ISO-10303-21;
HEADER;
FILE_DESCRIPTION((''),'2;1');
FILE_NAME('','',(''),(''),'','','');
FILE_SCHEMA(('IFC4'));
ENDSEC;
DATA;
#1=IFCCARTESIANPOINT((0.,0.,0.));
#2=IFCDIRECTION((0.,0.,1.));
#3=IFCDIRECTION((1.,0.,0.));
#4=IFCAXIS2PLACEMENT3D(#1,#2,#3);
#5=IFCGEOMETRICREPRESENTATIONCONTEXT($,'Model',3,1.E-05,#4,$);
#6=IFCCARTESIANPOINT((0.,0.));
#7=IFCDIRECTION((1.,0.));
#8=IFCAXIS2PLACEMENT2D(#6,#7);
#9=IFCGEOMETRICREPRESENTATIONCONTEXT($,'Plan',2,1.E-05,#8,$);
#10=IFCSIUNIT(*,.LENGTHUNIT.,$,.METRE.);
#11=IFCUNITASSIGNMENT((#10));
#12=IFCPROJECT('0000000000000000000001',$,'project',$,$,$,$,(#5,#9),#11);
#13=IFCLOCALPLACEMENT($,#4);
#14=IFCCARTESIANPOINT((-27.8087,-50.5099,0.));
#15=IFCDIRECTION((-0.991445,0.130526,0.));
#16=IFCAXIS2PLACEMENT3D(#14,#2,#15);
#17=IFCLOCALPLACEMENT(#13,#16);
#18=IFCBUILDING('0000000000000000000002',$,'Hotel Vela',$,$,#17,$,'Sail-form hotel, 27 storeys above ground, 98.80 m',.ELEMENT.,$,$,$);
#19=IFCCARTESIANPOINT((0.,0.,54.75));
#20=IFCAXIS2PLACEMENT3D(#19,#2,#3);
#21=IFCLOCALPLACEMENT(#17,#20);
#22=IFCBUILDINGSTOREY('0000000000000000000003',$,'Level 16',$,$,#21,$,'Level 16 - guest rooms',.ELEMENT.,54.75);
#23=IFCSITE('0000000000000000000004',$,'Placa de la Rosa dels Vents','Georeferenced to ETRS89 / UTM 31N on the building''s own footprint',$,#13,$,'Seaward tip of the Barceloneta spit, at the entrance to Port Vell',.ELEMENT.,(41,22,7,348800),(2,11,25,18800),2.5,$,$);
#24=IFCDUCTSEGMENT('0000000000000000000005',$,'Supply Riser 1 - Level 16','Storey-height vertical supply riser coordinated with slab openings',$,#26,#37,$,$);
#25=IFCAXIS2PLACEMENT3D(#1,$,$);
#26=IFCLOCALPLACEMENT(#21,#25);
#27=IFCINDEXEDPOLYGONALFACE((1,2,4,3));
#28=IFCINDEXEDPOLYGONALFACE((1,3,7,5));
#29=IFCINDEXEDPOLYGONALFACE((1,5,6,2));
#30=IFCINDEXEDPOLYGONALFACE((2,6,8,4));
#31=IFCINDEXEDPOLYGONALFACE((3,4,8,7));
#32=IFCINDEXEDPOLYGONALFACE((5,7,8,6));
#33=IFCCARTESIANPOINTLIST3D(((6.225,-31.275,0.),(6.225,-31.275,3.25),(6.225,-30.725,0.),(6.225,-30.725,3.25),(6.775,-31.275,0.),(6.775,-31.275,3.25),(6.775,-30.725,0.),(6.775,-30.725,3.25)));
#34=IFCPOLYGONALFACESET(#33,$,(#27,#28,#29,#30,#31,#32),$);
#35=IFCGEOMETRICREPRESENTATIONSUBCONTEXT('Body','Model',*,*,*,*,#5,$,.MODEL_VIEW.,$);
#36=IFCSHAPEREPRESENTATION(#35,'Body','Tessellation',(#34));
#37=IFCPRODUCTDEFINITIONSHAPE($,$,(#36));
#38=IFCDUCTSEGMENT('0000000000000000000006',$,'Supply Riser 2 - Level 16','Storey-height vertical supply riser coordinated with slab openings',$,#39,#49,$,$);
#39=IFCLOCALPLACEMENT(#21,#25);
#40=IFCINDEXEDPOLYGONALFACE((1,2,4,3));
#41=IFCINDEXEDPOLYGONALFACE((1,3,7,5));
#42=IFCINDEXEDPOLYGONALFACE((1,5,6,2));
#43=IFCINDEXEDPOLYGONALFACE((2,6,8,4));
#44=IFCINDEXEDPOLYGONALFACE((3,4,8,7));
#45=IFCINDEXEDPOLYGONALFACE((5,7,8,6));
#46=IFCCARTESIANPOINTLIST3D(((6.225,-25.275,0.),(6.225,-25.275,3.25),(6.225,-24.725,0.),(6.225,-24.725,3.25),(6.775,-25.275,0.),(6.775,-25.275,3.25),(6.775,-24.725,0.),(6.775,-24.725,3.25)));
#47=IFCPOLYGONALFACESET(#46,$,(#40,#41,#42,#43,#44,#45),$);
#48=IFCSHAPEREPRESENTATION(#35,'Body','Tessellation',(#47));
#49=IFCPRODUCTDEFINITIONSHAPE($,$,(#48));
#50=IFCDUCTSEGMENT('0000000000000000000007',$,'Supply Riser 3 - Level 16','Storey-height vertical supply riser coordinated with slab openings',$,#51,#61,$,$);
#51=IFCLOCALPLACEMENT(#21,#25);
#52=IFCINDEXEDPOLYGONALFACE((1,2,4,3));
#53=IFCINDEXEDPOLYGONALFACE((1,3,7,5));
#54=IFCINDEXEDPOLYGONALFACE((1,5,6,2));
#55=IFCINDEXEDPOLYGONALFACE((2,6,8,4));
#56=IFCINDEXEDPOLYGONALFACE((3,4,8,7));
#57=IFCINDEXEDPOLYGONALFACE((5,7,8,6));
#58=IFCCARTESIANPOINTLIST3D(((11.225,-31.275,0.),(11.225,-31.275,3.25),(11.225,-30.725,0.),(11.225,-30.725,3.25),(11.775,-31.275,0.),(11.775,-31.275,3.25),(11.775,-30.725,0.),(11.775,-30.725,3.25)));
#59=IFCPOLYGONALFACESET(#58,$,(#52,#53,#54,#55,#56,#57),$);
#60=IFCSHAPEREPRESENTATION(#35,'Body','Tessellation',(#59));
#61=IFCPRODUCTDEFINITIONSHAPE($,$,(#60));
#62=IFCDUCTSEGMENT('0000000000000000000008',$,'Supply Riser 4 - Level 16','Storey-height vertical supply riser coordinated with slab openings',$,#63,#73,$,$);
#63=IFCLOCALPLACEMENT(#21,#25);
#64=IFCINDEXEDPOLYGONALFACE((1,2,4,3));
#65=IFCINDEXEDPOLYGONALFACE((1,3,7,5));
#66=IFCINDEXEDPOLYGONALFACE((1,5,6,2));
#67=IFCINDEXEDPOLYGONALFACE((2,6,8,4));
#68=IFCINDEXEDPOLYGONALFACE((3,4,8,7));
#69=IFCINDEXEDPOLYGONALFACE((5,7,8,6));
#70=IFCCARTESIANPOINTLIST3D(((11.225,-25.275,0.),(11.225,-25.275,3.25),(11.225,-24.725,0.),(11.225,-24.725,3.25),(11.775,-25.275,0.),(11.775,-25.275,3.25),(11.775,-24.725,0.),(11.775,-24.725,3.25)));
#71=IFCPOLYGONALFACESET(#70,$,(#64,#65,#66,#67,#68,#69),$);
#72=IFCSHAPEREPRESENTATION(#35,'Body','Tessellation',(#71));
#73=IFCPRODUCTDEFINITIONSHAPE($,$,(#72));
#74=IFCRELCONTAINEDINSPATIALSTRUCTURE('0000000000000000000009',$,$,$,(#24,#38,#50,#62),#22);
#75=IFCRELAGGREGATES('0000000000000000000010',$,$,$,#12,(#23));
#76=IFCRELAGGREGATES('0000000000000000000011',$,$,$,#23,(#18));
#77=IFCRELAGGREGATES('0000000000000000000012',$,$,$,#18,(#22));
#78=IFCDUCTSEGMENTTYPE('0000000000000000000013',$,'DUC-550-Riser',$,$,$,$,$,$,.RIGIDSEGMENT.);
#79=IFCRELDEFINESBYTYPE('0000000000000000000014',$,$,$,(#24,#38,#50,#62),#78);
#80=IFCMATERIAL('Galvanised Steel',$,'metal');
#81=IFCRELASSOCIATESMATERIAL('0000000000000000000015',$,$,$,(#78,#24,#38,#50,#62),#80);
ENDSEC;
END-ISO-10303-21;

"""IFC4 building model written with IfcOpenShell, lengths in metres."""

from ifc_helpers import new_model, si_unit, frame, origin_with_axes, origin_2d_with_axis, place, context, subcontext, project, spatial, line, indexed_curve, outline, extrude, material, type_object, element, save


model = new_model("IFC4")

# Units and contexts
model_context = context("Model", 3, precision=1e-05, world=origin_with_axes())
plan_context = context("Plan", 2, precision=1e-05, world=origin_2d_with_axis())
body_context = subcontext(model_context, "Body", "Model", "MODEL_VIEW")
ifc_project = project(units=[si_unit("LENGTHUNIT", "METRE")], contexts=[model_context, plan_context])

# Site, building, storey
site_placement = place(None, origin_with_axes())
site = spatial("IfcSite", under=ifc_project, at=site_placement, Name="Placa de la Rosa dels Vents", Description="Georeferenced to ETRS89 / UTM 31N on the building's own footprint", LongName="Seaward tip of the Barceloneta spit, at the entrance to Port Vell", CompositionType="ELEMENT", RefLatitude=(41, 22, 7, 348800), RefLongitude=(2, 11, 25, 18800), RefElevation=2.5)
building_placement = place(site_placement, frame((-27.8087, -50.5099, 0.0), z_axis=(0.0, 0.0, 1.0), x_axis=(-0.991445, 0.130526, 0.0)))
building = spatial("IfcBuilding", under=site, at=building_placement, Name="Hotel Vela", LongName="Sail-form hotel, 27 storeys above ground, 98.80 m", CompositionType="ELEMENT")
storey_placement = place(building_placement, frame((0.0, 0.0, 54.75), z_axis=(0.0, 0.0, 1.0), x_axis=(1.0, 0.0, 0.0)))
storey = spatial("IfcBuildingStorey", under=building, at=storey_placement, Name="Level 16", LongName="Level 16 - guest rooms", CompositionType="ELEMENT", Elevation=54.75)

# Duct segments
ifc_material = material(Name="Galvanised Steel", Category="metal")
duct_segment_type = type_object("IfcDuctSegmentType", Name="DUC-550-Riser", PredefinedType="RIGIDSEGMENT", material=ifc_material)
for number, where, z_axis, x_axis, name in (
    (1, (6.225, -31.275, 0.0), (0.0, 0.0, 1.0), (1.0, 0.0, 0.0), "Supply Riser 1 - Level 16"),
    (2, (6.225, -25.275, 0.0), (0.0, 0.0, 1.0), (1.0, 0.0, 0.0), "Supply Riser 2 - Level 16"),
    (3, (11.225, -31.275, 0.0), (0.0, 0.0, 1.0), (1.0, 0.0, 0.0), "Supply Riser 3 - Level 16"),
    (4, (11.225, -25.275, 0.0), (0.0, 0.0, 1.0), (1.0, 0.0, 0.0), "Supply Riser 4 - Level 16"),
):
    element("IfcDuctSegment", number, at=place(storey_placement, frame(where, z_axis=z_axis, x_axis=x_axis)), inside=storey, type_object=duct_segment_type, material=ifc_material, Name=name, Description="Storey-height vertical supply riser coordinated with slab openings", context=body_context, shape_type="SweptSolid", body=[
        extrude(outline(indexed_curve([(0.0, 0.0), (0.55, 0.0), (0.55, 0.55), (0.0, 0.55)], segments=[line(1, 2, 3, 4, 1)])), origin_with_axes(), (0.0, 0.0, 1.0), 3.25),
    ])

save(model, "model.ifc")
